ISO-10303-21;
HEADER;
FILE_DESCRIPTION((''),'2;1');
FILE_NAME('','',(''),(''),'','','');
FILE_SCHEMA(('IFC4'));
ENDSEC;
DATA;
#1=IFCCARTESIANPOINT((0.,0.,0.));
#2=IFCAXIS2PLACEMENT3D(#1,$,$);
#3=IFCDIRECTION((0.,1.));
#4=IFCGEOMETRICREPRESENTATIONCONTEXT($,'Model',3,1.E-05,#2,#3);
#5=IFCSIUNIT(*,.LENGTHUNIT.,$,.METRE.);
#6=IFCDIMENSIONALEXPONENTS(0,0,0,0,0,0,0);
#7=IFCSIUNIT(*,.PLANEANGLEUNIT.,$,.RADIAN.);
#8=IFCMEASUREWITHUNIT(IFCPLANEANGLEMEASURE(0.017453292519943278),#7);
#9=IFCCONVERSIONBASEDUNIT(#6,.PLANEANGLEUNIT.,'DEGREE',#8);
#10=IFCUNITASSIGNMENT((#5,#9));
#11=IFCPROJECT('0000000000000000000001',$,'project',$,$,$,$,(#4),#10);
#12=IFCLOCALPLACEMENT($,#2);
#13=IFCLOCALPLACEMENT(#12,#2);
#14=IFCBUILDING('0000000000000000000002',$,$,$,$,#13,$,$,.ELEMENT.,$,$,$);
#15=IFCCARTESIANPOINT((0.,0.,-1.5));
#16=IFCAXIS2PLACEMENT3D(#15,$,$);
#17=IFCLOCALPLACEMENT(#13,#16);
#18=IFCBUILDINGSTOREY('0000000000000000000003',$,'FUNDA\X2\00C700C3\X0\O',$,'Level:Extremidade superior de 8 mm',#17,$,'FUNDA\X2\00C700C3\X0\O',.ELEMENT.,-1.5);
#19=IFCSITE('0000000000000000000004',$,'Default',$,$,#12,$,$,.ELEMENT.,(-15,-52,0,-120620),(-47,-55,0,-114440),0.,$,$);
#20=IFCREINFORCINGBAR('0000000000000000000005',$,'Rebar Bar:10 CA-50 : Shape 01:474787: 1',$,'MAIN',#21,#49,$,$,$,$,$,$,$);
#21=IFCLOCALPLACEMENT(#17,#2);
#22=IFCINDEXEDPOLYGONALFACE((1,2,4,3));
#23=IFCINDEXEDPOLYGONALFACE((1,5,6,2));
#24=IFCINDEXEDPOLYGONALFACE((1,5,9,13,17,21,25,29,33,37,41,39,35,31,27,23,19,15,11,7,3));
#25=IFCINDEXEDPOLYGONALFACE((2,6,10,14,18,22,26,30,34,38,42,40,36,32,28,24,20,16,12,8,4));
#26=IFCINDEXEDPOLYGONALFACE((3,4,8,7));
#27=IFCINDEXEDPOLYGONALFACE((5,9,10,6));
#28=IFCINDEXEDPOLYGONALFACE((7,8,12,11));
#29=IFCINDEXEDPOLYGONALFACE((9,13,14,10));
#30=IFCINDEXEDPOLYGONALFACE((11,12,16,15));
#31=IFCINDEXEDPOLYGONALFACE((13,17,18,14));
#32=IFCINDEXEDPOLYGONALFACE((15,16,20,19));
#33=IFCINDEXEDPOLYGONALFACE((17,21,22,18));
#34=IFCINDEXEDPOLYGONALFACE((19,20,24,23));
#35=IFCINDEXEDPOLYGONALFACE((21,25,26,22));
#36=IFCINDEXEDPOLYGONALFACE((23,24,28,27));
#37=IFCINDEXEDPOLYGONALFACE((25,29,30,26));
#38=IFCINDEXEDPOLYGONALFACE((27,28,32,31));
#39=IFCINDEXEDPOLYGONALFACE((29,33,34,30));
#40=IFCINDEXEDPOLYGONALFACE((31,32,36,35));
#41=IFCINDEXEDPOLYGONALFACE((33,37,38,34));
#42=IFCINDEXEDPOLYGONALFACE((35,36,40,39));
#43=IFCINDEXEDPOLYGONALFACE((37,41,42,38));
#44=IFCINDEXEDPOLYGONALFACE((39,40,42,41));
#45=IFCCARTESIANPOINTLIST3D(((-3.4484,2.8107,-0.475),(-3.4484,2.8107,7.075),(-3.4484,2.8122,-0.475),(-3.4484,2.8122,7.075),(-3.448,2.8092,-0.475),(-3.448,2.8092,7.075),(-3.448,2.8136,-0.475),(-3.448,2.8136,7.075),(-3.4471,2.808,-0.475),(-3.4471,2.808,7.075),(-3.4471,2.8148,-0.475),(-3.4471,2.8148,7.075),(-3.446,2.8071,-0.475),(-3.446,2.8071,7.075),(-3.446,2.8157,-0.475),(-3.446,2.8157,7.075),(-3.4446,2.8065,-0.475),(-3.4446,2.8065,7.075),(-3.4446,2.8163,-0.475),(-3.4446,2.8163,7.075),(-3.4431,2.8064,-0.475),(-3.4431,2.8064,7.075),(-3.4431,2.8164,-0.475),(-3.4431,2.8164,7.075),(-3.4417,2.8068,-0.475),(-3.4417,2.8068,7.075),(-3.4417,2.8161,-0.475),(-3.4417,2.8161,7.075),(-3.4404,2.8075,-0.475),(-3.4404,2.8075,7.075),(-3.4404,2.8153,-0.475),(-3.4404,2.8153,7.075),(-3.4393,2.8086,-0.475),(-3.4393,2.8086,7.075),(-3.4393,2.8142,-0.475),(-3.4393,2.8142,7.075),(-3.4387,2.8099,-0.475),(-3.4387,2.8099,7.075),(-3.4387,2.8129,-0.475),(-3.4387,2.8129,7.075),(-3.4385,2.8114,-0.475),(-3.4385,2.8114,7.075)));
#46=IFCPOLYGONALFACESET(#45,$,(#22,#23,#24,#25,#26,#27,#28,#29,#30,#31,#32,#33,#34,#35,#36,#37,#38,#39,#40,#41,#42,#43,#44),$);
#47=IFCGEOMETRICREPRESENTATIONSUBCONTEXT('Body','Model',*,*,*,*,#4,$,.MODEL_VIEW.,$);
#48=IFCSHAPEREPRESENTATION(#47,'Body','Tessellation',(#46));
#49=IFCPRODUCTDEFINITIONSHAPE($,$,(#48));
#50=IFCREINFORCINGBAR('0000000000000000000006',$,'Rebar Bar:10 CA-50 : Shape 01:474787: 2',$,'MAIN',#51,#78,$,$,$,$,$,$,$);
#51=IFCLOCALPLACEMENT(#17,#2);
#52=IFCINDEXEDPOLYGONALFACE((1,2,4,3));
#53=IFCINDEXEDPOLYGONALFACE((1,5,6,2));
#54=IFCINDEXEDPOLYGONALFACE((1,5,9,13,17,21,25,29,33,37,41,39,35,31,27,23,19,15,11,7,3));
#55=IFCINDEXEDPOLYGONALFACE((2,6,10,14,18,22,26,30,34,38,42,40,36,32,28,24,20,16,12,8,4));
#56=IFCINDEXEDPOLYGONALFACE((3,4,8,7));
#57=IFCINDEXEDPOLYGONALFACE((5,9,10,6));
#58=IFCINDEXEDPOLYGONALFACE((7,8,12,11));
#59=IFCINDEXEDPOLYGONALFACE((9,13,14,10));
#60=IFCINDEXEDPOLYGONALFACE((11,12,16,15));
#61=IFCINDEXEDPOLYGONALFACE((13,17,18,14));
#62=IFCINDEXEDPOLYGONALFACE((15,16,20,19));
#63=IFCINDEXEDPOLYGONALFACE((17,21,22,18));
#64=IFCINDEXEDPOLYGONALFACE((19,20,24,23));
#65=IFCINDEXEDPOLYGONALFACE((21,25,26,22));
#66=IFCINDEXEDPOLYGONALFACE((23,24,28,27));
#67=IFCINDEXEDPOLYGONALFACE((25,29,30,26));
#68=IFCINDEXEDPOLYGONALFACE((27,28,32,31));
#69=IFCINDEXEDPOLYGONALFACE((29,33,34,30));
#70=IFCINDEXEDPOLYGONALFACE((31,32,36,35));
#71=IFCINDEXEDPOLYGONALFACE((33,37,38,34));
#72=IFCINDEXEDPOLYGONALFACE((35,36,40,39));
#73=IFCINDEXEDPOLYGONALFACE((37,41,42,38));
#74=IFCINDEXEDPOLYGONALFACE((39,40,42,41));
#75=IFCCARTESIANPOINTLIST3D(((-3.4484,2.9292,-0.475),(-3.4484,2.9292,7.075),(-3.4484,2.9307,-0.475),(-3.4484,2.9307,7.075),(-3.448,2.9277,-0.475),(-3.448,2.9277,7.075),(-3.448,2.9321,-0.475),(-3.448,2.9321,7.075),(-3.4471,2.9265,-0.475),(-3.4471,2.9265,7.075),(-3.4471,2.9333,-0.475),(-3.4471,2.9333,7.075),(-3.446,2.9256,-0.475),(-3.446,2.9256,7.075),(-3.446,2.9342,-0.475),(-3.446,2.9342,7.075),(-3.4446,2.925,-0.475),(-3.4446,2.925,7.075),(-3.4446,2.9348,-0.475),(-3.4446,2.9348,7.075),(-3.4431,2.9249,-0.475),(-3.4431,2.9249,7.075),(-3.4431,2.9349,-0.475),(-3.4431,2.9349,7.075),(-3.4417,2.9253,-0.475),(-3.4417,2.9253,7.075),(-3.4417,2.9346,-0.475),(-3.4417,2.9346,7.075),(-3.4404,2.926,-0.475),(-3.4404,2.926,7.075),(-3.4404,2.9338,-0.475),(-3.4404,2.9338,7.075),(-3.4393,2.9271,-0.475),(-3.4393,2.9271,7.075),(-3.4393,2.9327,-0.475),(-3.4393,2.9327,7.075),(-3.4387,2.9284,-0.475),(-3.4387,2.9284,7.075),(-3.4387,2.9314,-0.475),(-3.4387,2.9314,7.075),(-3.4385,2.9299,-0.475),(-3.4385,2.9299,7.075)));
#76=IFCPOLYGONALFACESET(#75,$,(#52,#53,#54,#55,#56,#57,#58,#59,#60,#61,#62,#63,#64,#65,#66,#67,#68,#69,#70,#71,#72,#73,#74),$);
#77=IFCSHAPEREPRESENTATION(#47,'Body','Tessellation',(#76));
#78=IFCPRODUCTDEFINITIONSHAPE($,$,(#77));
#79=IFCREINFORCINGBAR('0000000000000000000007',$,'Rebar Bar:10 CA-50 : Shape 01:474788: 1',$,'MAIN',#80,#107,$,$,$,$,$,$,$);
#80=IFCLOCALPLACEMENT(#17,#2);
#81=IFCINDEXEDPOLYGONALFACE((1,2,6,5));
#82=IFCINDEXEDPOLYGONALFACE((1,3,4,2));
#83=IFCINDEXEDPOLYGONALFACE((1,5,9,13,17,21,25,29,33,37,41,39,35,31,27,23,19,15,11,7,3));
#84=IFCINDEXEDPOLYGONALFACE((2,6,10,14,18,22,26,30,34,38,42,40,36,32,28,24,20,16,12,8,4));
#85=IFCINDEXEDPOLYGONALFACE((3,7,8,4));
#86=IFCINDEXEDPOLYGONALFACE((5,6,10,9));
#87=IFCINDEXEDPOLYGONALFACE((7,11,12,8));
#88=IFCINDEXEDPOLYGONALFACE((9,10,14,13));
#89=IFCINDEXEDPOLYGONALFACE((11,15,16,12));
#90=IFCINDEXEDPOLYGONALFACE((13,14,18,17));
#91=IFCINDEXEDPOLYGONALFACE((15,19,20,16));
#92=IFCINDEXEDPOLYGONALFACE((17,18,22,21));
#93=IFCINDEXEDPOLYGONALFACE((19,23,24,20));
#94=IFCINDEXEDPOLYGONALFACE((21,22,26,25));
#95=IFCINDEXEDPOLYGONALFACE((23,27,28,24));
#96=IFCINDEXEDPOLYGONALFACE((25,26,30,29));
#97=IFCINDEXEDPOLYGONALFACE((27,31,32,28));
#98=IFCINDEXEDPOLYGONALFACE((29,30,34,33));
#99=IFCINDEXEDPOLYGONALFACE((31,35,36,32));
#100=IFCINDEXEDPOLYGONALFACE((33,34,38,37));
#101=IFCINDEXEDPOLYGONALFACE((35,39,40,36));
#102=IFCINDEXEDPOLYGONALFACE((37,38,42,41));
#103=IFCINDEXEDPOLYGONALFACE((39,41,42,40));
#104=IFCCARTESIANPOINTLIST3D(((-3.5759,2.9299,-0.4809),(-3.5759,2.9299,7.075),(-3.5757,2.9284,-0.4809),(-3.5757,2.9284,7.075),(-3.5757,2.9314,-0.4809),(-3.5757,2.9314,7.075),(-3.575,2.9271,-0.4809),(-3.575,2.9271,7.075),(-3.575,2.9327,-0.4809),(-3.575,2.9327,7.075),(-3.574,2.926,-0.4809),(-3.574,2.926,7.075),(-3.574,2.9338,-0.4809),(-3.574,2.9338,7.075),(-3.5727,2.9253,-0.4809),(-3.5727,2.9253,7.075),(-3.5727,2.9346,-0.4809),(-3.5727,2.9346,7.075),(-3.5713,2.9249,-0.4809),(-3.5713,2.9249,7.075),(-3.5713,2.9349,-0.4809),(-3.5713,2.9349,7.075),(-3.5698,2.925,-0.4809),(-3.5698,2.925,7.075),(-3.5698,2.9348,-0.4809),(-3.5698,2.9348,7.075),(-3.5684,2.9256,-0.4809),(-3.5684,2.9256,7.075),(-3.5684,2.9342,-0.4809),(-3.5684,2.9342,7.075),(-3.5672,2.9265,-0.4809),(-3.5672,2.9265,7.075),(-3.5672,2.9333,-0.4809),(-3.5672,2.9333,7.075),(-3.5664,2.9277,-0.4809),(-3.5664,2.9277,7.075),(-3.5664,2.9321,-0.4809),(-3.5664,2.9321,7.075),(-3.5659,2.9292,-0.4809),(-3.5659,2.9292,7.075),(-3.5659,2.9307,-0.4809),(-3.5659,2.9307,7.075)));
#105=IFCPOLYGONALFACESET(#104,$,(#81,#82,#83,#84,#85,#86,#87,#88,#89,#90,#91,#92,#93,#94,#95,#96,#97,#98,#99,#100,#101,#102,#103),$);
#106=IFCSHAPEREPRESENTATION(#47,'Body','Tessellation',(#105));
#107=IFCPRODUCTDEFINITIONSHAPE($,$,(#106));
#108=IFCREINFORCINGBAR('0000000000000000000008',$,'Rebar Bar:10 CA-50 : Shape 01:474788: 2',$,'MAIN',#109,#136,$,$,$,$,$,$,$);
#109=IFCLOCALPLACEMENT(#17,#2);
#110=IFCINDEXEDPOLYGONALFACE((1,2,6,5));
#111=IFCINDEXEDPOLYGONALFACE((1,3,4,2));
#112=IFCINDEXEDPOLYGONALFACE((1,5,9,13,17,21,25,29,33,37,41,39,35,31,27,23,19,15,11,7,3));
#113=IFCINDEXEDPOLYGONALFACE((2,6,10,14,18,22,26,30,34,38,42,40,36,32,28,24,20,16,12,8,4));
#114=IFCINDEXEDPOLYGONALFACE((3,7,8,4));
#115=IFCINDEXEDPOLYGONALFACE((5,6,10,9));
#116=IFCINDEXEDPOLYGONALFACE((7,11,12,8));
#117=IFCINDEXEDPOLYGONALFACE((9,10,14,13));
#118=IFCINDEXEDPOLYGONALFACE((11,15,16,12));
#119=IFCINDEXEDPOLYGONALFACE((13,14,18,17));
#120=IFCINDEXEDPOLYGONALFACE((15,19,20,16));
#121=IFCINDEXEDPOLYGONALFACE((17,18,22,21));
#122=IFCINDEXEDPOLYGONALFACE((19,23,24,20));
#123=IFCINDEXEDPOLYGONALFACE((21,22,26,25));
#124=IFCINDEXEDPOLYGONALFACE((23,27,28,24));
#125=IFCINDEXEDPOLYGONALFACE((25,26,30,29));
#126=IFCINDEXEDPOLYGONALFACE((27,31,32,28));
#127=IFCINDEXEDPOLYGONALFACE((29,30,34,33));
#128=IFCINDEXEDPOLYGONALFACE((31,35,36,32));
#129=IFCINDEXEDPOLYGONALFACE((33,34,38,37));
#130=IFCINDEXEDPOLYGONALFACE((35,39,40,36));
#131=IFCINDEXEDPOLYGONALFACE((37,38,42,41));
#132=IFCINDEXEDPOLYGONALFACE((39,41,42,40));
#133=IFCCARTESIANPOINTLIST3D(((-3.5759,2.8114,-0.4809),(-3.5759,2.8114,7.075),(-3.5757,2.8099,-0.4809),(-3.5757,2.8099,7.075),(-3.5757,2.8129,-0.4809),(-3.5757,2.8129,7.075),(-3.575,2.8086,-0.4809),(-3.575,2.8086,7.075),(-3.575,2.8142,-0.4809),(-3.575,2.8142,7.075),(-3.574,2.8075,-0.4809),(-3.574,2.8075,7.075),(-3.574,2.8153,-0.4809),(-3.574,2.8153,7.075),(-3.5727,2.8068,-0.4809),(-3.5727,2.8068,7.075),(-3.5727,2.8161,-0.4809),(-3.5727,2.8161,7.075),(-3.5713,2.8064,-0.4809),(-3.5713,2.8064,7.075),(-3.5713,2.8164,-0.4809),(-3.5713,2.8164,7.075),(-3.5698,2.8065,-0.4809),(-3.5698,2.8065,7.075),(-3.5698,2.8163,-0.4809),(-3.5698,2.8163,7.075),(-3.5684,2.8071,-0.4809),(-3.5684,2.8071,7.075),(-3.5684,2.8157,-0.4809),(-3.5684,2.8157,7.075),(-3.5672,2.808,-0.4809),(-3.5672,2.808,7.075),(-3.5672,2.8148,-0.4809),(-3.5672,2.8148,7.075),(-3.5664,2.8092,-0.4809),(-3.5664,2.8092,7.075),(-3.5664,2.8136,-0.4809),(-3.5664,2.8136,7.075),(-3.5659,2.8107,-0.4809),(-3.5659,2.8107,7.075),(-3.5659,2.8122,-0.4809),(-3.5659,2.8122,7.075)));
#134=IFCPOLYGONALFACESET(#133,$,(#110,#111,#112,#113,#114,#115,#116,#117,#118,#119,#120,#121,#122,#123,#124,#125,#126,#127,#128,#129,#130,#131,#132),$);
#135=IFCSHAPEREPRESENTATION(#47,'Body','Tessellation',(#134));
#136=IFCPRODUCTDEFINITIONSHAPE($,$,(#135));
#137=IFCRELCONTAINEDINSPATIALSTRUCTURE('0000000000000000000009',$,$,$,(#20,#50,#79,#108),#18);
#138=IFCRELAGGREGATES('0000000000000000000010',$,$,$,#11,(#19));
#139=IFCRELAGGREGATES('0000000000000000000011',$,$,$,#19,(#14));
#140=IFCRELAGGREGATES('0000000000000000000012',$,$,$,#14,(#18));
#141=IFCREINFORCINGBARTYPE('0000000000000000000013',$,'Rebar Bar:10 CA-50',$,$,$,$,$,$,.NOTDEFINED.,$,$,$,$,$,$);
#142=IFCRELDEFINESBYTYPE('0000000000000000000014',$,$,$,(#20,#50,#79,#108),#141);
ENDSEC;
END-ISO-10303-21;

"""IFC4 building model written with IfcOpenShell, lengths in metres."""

from ifc_helpers import new_model, entity, si_unit, converted_unit, direction, frame, origin, place, context, subcontext, project, spatial, type_object, element, save


model = new_model("IFC4")

# Units and contexts
model_context = context("Model", 3, precision=1e-05, world=origin(), true_north=direction((0.0, 1.0)))
body_context = subcontext(model_context, "Body", "Model", "MODEL_VIEW")
ifc_project = project(units=[si_unit("LENGTHUNIT", "METRE"), converted_unit("PLANEANGLEUNIT", "DEGREE", entity("IfcPlaneAngleMeasure", 0.017453292519943278), si_unit("PLANEANGLEUNIT", "RADIAN"), dimensions=[0, 0, 0, 0, 0, 0, 0])], contexts=[model_context])

# Site, building, storey
site_placement = place(None, origin())
site = spatial("IfcSite", under=ifc_project, at=site_placement, Name="Default", CompositionType="ELEMENT", RefLatitude=(-15, -52, 0, -120620), RefLongitude=(-47, -55, 0, -114440), RefElevation=0.0)
building_placement = place(site_placement, origin())
building = spatial("IfcBuilding", under=site, at=building_placement, CompositionType="ELEMENT")
storey_placement = place(building_placement, frame((0.0, 0.0, -1.5)))
storey = spatial("IfcBuildingStorey", under=building, at=storey_placement, Name="FUNDAÇÃO", ObjectType="Level:Extremidade superior de 8 mm", LongName="FUNDAÇÃO", CompositionType="ELEMENT", Elevation=-1.5)

# Reinforcing bars
reinforcing_bar_type_1 = type_object("IfcReinforcingBarType", Name="Rebar Bar:10 CA-50", PredefinedType="NOTDEFINED")
reinforcing_bar_1_placement = place(storey_placement, origin())
element("IfcReinforcingBar", 1, at=reinforcing_bar_1_placement, inside=storey, type_object=reinforcing_bar_type_1, Name="Rebar Bar:10 CA-50 : Shape 01:474787: 1", ObjectType="MAIN", context=body_context, shape_type="AdvancedSweptSolid", body=[
    entity("IfcSweptDiskSolid", entity("IfcIndexedPolyCurve", entity("IfcCartesianPointList3D", [[-3.4435, 2.8114, -0.475], [-3.4435, 2.8114, 7.075]]), None, False), 0.005, None, 0.0, 1.0),
])
reinforcing_bar_2_placement = place(storey_placement, origin())
element("IfcReinforcingBar", 2, at=reinforcing_bar_2_placement, inside=storey, type_object=reinforcing_bar_type_1, Name="Rebar Bar:10 CA-50 : Shape 01:474787: 2", ObjectType="MAIN", context=body_context, shape_type="AdvancedSweptSolid", body=[
    entity("IfcSweptDiskSolid", entity("IfcIndexedPolyCurve", entity("IfcCartesianPointList3D", [[-3.4435, 2.9299, -0.475], [-3.4435, 2.9299, 7.075]]), None, False), 0.005, None, 0.0, 1.0),
])
reinforcing_bar_3_placement = place(storey_placement, origin())
element("IfcReinforcingBar", 3, at=reinforcing_bar_3_placement, inside=storey, type_object=reinforcing_bar_type_1, Name="Rebar Bar:10 CA-50 : Shape 01:474788: 1", ObjectType="MAIN", context=body_context, shape_type="AdvancedSweptSolid", body=[
    entity("IfcSweptDiskSolid", entity("IfcIndexedPolyCurve", entity("IfcCartesianPointList3D", [[-3.5709, 2.9299, 7.075], [-3.5709, 2.9299, -0.4809]]), None, False), 0.005, None, 0.0, 1.0),
])
reinforcing_bar_4_placement = place(storey_placement, origin())
element("IfcReinforcingBar", 4, at=reinforcing_bar_4_placement, inside=storey, type_object=reinforcing_bar_type_1, Name="Rebar Bar:10 CA-50 : Shape 01:474788: 2", ObjectType="MAIN", context=body_context, shape_type="AdvancedSweptSolid", body=[
    entity("IfcSweptDiskSolid", entity("IfcIndexedPolyCurve", entity("IfcCartesianPointList3D", [[-3.5709, 2.8114, 7.075], [-3.5709, 2.8114, -0.4809]]), None, False), 0.005, None, 0.0, 1.0),
])

save(model, "model.ifc")
